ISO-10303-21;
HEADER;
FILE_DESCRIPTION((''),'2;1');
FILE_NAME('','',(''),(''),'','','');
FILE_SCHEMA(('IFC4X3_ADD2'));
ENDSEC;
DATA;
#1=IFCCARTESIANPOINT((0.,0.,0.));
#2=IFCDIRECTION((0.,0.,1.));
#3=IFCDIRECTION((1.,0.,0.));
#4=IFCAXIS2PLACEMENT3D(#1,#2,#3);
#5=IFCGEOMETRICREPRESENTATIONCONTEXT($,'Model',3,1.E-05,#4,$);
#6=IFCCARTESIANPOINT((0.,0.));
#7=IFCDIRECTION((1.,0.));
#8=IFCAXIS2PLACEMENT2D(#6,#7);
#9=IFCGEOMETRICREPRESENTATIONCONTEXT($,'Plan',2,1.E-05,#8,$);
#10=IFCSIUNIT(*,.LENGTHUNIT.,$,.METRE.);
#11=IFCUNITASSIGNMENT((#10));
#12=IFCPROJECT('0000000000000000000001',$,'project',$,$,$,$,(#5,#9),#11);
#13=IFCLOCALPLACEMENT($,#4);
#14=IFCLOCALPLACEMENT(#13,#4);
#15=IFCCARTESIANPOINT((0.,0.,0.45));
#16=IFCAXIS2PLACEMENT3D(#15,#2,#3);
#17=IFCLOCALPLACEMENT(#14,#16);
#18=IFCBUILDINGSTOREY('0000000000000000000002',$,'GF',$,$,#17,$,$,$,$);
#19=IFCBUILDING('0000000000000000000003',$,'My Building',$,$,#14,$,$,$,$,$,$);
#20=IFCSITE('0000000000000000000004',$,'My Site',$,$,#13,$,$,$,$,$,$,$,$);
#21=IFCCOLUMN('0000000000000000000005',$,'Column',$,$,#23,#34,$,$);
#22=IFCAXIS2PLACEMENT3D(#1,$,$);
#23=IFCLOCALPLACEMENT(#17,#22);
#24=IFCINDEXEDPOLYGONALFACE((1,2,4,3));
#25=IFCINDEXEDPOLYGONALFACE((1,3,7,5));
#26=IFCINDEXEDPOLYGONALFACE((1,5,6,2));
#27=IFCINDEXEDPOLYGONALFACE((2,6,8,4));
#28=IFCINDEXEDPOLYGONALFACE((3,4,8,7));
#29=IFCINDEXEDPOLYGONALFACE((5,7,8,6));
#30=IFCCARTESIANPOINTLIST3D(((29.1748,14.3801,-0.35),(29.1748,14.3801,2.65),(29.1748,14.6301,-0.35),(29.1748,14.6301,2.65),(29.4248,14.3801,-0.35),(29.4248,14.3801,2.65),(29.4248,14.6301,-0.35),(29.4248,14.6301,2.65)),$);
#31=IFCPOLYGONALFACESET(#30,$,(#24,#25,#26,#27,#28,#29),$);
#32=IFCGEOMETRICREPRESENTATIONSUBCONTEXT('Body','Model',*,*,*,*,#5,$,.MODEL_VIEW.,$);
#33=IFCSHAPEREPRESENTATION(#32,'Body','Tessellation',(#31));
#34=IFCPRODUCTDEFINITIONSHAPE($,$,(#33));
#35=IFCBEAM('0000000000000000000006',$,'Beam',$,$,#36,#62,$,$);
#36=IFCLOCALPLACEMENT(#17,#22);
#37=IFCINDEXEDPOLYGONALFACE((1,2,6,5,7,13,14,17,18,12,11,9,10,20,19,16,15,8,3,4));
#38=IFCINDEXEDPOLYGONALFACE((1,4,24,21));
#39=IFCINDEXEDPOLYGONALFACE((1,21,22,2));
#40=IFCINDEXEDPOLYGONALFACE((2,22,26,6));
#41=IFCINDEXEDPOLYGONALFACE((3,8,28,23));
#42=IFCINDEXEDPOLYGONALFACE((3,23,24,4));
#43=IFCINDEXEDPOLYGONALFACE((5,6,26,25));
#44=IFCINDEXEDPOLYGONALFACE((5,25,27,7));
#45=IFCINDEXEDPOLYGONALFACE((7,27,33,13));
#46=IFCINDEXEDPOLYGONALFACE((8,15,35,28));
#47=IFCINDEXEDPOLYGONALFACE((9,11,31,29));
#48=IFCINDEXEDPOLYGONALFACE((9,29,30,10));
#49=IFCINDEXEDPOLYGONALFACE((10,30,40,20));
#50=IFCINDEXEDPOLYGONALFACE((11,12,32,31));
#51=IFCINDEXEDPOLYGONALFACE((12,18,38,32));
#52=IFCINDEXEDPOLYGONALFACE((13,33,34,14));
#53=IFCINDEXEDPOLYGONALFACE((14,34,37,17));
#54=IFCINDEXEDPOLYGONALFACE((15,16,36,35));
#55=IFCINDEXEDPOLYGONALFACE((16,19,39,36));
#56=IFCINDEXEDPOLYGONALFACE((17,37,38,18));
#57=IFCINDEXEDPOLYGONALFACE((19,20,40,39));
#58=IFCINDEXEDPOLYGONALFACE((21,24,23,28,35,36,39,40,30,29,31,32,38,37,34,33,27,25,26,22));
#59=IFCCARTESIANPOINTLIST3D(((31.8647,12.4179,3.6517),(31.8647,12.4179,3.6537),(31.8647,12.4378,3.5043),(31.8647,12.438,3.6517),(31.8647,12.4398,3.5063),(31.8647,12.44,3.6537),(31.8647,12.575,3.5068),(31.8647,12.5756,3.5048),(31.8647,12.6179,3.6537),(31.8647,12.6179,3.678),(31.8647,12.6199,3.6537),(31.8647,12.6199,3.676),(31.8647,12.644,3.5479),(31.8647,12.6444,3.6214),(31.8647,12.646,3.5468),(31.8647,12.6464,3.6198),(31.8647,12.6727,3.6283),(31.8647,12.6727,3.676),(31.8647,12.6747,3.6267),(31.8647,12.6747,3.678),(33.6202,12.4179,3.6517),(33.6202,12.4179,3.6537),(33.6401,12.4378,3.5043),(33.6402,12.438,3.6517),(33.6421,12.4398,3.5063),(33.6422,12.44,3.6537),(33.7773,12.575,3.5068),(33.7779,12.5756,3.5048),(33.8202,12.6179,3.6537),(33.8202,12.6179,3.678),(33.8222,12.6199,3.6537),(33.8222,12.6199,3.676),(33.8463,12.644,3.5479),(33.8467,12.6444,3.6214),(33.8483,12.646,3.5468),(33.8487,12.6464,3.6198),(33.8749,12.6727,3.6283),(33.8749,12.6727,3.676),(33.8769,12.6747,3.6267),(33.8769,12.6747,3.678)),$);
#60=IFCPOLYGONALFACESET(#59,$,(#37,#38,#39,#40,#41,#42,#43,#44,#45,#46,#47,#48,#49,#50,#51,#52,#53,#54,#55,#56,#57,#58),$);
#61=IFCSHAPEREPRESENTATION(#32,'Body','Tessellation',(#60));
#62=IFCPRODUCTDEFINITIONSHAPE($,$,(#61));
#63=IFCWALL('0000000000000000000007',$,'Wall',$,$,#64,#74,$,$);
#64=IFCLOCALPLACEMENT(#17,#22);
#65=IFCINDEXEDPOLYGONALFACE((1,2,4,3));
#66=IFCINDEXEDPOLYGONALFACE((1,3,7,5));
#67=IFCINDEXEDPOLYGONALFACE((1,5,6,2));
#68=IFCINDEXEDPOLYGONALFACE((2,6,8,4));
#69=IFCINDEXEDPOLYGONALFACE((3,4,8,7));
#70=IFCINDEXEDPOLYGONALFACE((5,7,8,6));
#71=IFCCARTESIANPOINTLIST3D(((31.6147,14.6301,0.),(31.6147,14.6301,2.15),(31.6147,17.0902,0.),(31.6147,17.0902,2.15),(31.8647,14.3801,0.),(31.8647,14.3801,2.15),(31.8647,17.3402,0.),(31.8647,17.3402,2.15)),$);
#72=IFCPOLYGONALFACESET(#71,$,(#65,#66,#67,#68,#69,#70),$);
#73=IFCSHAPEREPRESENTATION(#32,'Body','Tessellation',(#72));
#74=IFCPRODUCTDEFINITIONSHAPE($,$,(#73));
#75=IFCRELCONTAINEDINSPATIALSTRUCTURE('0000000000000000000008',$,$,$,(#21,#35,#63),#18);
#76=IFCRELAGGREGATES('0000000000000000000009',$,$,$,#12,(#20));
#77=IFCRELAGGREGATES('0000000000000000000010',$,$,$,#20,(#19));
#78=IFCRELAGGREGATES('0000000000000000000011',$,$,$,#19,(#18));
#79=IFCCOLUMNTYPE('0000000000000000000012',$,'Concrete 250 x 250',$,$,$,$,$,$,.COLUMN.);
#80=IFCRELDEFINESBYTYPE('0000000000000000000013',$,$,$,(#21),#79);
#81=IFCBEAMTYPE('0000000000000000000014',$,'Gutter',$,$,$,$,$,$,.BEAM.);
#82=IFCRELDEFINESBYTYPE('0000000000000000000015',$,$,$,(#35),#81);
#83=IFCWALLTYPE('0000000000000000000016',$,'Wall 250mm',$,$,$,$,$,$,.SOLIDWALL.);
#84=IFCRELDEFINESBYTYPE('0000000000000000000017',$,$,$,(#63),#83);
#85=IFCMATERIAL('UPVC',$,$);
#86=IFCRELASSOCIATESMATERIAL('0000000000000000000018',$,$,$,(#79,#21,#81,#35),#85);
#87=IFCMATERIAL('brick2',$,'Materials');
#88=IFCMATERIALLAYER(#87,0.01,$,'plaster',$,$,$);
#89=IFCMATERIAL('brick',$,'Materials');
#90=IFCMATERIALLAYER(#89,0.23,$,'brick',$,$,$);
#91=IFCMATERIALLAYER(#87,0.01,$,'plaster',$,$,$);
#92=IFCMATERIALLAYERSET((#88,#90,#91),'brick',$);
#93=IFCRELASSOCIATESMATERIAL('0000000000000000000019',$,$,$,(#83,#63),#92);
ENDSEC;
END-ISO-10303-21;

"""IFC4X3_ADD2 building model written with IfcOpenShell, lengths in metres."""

from ifc_helpers import new_model, si_unit, frame, origin_with_axes, origin_2d_with_axis, place, context, subcontext, project, spatial, line, indexed_curve, rectangle, outline, extrude, clip, halfspace, material, layer, layer_set, layer_usage, material_profile, profile_set, profile_usage, type_object, element, save


model = new_model("IFC4X3_ADD2")

# Units and contexts
model_context = context("Model", 3, precision=1e-05, world=origin_with_axes())
plan_context = context("Plan", 2, precision=1e-05, world=origin_2d_with_axis())
body_context_1 = subcontext(model_context, "Body", "Model", "MODEL_VIEW")
ifc_project = project(units=[si_unit("LENGTHUNIT", "METRE")], contexts=[model_context, plan_context])

# Site, building, storey
site_placement = place(None, origin_with_axes())
site = spatial("IfcSite", under=ifc_project, at=site_placement, Name="My Site")
building_placement = place(site_placement, origin_with_axes())
building = spatial("IfcBuilding", under=site, at=building_placement, Name="My Building")
storey_placement = place(building_placement, frame((0.0, 0.0, 0.45), z_axis=(0.0, 0.0, 1.0), x_axis=(1.0, 0.0, 0.0)))
storey = spatial("IfcBuildingStorey", under=building, at=storey_placement, Name="GF")

# Column
ifc_material_1 = material(Name="UPVC")
ifc_material_profile_1 = material_profile(ifc_material_1, rectangle(XDim=0.25, YDim=0.25))
ifc_profile_set_1 = profile_set([ifc_material_profile_1], Name="rcc")
ifc_profile_usage_1 = profile_usage(ifc_profile_set_1, cardinal=5)
column_type = type_object("IfcColumnType", Name="Concrete 250 x 250", PredefinedType="COLUMN", material=ifc_profile_set_1)
column_placement = place(storey_placement, frame((29.2998, 14.5051, -0.35), z_axis=(0.0, 0.0, 1.0), x_axis=(1.0, 0.0, 0.0)))
element("IfcColumn", 1, at=column_placement, inside=storey, type_object=column_type, material=ifc_profile_usage_1, Name="Column", context=body_context_1, shape_type="SweptSolid", body=[
    extrude(rectangle(XDim=0.25, YDim=0.25), origin_with_axes(), (0.0, 0.0, 1.0), 3.0),
])

# Beam
ifc_material_profile_2 = material_profile(ifc_material_1, outline(indexed_curve([(0.0548, 0.1717), (0.002, 0.1717), (0.002, 0.124), (0.0303, 0.1171), (0.0307, 0.0436), (0.0996, 0.0025), (0.2349, 0.002), (0.2347, 0.1494), (0.2567, 0.1494), (0.2567, 0.1474), (0.2367, 0.1474), (0.2369, 0.0), (0.0991, 0.0005), (0.0287, 0.0425), (0.0283, 0.1155), (0.0, 0.1224), (0.0, 0.1737), (0.0568, 0.1737), (0.0568, 0.1494), (0.0548, 0.1494), (0.0548, 0.1717)])))
ifc_profile_set_2 = profile_set([ifc_material_profile_2])
ifc_profile_usage_2 = profile_usage(ifc_profile_set_2)
beam_type = type_object("IfcBeamType", Name="Gutter", PredefinedType="BEAM", material=ifc_profile_set_2)
beam_placement = place(storey_placement, frame((33.8769, 12.6747, 3.5043), z_axis=(-1.0, 0.000001, 0.0), x_axis=(-0.000001, -1.0, 0.0)))
element("IfcBeam", 2, at=beam_placement, inside=storey, type_object=beam_type, material=ifc_profile_usage_2, Name="Beam", context=body_context_1, shape_type="Clipping", body=[
    clip(extrude(outline(indexed_curve([(0.0548, 0.1717), (0.002, 0.1717), (0.002, 0.124), (0.0303, 0.1171), (0.0307, 0.0436), (0.0996, 0.0025), (0.2349, 0.002), (0.2347, 0.1494), (0.2567, 0.1494), (0.2567, 0.1474), (0.2367, 0.1474), (0.2369, 0.0), (0.0991, 0.0005), (0.0287, 0.0425), (0.0283, 0.1155), (0.0, 0.1224), (0.0, 0.1737), (0.0568, 0.1737), (0.0568, 0.1494), (0.0548, 0.1494), (0.0548, 0.1717)])), origin_with_axes(), (0.0, 0.0, 1.0), 2.0122), halfspace(frame((0.0, -3.9543, 0.0), z_axis=(0.707109, 0.0, -0.707105), x_axis=(0.0, -1.0, 0.0)), False)),
])

# Wall
ifc_material_2 = material(Name="brick2", Category="Materials")
ifc_layer_1 = layer(ifc_material_2, 0.01, Name="plaster")
ifc_material_3 = material(Name="brick", Category="Materials")
ifc_layer_2 = layer(ifc_material_3, 0.23, Name="brick")
ifc_layer_3 = layer(ifc_material_2, 0.01, Name="plaster")
ifc_layer_set_1 = layer_set([ifc_layer_1, ifc_layer_2, ifc_layer_3], Name="brick")
ifc_layer_usage_1 = layer_usage(ifc_layer_set_1, "AXIS2", "POSITIVE", 0.0)
wall_type_1 = type_object("IfcWallType", Name="Wall 250mm", PredefinedType="SOLIDWALL", material=ifc_layer_set_1)
wall_1_placement = place(storey_placement, frame((31.8647, 14.3801, 0.0), z_axis=(0.0, 0.0, 1.0), x_axis=(0.000001, 1.0, 0.0)))
element("IfcWall", 3, at=wall_1_placement, inside=storey, type_object=wall_type_1, material=ifc_layer_usage_1, Name="Wall", context=body_context_1, shape_type="SweptSolid", body=[
    extrude(outline(indexed_curve([(0.0, 0.0), (0.25, 0.25), (2.71, 0.25), (2.96, 0.0)], segments=[line(1, 2, 3, 4, 1)])), origin_with_axes(), (0.0, 0.0, 1.0), 2.15),
])

save(model, "model.ifc")
